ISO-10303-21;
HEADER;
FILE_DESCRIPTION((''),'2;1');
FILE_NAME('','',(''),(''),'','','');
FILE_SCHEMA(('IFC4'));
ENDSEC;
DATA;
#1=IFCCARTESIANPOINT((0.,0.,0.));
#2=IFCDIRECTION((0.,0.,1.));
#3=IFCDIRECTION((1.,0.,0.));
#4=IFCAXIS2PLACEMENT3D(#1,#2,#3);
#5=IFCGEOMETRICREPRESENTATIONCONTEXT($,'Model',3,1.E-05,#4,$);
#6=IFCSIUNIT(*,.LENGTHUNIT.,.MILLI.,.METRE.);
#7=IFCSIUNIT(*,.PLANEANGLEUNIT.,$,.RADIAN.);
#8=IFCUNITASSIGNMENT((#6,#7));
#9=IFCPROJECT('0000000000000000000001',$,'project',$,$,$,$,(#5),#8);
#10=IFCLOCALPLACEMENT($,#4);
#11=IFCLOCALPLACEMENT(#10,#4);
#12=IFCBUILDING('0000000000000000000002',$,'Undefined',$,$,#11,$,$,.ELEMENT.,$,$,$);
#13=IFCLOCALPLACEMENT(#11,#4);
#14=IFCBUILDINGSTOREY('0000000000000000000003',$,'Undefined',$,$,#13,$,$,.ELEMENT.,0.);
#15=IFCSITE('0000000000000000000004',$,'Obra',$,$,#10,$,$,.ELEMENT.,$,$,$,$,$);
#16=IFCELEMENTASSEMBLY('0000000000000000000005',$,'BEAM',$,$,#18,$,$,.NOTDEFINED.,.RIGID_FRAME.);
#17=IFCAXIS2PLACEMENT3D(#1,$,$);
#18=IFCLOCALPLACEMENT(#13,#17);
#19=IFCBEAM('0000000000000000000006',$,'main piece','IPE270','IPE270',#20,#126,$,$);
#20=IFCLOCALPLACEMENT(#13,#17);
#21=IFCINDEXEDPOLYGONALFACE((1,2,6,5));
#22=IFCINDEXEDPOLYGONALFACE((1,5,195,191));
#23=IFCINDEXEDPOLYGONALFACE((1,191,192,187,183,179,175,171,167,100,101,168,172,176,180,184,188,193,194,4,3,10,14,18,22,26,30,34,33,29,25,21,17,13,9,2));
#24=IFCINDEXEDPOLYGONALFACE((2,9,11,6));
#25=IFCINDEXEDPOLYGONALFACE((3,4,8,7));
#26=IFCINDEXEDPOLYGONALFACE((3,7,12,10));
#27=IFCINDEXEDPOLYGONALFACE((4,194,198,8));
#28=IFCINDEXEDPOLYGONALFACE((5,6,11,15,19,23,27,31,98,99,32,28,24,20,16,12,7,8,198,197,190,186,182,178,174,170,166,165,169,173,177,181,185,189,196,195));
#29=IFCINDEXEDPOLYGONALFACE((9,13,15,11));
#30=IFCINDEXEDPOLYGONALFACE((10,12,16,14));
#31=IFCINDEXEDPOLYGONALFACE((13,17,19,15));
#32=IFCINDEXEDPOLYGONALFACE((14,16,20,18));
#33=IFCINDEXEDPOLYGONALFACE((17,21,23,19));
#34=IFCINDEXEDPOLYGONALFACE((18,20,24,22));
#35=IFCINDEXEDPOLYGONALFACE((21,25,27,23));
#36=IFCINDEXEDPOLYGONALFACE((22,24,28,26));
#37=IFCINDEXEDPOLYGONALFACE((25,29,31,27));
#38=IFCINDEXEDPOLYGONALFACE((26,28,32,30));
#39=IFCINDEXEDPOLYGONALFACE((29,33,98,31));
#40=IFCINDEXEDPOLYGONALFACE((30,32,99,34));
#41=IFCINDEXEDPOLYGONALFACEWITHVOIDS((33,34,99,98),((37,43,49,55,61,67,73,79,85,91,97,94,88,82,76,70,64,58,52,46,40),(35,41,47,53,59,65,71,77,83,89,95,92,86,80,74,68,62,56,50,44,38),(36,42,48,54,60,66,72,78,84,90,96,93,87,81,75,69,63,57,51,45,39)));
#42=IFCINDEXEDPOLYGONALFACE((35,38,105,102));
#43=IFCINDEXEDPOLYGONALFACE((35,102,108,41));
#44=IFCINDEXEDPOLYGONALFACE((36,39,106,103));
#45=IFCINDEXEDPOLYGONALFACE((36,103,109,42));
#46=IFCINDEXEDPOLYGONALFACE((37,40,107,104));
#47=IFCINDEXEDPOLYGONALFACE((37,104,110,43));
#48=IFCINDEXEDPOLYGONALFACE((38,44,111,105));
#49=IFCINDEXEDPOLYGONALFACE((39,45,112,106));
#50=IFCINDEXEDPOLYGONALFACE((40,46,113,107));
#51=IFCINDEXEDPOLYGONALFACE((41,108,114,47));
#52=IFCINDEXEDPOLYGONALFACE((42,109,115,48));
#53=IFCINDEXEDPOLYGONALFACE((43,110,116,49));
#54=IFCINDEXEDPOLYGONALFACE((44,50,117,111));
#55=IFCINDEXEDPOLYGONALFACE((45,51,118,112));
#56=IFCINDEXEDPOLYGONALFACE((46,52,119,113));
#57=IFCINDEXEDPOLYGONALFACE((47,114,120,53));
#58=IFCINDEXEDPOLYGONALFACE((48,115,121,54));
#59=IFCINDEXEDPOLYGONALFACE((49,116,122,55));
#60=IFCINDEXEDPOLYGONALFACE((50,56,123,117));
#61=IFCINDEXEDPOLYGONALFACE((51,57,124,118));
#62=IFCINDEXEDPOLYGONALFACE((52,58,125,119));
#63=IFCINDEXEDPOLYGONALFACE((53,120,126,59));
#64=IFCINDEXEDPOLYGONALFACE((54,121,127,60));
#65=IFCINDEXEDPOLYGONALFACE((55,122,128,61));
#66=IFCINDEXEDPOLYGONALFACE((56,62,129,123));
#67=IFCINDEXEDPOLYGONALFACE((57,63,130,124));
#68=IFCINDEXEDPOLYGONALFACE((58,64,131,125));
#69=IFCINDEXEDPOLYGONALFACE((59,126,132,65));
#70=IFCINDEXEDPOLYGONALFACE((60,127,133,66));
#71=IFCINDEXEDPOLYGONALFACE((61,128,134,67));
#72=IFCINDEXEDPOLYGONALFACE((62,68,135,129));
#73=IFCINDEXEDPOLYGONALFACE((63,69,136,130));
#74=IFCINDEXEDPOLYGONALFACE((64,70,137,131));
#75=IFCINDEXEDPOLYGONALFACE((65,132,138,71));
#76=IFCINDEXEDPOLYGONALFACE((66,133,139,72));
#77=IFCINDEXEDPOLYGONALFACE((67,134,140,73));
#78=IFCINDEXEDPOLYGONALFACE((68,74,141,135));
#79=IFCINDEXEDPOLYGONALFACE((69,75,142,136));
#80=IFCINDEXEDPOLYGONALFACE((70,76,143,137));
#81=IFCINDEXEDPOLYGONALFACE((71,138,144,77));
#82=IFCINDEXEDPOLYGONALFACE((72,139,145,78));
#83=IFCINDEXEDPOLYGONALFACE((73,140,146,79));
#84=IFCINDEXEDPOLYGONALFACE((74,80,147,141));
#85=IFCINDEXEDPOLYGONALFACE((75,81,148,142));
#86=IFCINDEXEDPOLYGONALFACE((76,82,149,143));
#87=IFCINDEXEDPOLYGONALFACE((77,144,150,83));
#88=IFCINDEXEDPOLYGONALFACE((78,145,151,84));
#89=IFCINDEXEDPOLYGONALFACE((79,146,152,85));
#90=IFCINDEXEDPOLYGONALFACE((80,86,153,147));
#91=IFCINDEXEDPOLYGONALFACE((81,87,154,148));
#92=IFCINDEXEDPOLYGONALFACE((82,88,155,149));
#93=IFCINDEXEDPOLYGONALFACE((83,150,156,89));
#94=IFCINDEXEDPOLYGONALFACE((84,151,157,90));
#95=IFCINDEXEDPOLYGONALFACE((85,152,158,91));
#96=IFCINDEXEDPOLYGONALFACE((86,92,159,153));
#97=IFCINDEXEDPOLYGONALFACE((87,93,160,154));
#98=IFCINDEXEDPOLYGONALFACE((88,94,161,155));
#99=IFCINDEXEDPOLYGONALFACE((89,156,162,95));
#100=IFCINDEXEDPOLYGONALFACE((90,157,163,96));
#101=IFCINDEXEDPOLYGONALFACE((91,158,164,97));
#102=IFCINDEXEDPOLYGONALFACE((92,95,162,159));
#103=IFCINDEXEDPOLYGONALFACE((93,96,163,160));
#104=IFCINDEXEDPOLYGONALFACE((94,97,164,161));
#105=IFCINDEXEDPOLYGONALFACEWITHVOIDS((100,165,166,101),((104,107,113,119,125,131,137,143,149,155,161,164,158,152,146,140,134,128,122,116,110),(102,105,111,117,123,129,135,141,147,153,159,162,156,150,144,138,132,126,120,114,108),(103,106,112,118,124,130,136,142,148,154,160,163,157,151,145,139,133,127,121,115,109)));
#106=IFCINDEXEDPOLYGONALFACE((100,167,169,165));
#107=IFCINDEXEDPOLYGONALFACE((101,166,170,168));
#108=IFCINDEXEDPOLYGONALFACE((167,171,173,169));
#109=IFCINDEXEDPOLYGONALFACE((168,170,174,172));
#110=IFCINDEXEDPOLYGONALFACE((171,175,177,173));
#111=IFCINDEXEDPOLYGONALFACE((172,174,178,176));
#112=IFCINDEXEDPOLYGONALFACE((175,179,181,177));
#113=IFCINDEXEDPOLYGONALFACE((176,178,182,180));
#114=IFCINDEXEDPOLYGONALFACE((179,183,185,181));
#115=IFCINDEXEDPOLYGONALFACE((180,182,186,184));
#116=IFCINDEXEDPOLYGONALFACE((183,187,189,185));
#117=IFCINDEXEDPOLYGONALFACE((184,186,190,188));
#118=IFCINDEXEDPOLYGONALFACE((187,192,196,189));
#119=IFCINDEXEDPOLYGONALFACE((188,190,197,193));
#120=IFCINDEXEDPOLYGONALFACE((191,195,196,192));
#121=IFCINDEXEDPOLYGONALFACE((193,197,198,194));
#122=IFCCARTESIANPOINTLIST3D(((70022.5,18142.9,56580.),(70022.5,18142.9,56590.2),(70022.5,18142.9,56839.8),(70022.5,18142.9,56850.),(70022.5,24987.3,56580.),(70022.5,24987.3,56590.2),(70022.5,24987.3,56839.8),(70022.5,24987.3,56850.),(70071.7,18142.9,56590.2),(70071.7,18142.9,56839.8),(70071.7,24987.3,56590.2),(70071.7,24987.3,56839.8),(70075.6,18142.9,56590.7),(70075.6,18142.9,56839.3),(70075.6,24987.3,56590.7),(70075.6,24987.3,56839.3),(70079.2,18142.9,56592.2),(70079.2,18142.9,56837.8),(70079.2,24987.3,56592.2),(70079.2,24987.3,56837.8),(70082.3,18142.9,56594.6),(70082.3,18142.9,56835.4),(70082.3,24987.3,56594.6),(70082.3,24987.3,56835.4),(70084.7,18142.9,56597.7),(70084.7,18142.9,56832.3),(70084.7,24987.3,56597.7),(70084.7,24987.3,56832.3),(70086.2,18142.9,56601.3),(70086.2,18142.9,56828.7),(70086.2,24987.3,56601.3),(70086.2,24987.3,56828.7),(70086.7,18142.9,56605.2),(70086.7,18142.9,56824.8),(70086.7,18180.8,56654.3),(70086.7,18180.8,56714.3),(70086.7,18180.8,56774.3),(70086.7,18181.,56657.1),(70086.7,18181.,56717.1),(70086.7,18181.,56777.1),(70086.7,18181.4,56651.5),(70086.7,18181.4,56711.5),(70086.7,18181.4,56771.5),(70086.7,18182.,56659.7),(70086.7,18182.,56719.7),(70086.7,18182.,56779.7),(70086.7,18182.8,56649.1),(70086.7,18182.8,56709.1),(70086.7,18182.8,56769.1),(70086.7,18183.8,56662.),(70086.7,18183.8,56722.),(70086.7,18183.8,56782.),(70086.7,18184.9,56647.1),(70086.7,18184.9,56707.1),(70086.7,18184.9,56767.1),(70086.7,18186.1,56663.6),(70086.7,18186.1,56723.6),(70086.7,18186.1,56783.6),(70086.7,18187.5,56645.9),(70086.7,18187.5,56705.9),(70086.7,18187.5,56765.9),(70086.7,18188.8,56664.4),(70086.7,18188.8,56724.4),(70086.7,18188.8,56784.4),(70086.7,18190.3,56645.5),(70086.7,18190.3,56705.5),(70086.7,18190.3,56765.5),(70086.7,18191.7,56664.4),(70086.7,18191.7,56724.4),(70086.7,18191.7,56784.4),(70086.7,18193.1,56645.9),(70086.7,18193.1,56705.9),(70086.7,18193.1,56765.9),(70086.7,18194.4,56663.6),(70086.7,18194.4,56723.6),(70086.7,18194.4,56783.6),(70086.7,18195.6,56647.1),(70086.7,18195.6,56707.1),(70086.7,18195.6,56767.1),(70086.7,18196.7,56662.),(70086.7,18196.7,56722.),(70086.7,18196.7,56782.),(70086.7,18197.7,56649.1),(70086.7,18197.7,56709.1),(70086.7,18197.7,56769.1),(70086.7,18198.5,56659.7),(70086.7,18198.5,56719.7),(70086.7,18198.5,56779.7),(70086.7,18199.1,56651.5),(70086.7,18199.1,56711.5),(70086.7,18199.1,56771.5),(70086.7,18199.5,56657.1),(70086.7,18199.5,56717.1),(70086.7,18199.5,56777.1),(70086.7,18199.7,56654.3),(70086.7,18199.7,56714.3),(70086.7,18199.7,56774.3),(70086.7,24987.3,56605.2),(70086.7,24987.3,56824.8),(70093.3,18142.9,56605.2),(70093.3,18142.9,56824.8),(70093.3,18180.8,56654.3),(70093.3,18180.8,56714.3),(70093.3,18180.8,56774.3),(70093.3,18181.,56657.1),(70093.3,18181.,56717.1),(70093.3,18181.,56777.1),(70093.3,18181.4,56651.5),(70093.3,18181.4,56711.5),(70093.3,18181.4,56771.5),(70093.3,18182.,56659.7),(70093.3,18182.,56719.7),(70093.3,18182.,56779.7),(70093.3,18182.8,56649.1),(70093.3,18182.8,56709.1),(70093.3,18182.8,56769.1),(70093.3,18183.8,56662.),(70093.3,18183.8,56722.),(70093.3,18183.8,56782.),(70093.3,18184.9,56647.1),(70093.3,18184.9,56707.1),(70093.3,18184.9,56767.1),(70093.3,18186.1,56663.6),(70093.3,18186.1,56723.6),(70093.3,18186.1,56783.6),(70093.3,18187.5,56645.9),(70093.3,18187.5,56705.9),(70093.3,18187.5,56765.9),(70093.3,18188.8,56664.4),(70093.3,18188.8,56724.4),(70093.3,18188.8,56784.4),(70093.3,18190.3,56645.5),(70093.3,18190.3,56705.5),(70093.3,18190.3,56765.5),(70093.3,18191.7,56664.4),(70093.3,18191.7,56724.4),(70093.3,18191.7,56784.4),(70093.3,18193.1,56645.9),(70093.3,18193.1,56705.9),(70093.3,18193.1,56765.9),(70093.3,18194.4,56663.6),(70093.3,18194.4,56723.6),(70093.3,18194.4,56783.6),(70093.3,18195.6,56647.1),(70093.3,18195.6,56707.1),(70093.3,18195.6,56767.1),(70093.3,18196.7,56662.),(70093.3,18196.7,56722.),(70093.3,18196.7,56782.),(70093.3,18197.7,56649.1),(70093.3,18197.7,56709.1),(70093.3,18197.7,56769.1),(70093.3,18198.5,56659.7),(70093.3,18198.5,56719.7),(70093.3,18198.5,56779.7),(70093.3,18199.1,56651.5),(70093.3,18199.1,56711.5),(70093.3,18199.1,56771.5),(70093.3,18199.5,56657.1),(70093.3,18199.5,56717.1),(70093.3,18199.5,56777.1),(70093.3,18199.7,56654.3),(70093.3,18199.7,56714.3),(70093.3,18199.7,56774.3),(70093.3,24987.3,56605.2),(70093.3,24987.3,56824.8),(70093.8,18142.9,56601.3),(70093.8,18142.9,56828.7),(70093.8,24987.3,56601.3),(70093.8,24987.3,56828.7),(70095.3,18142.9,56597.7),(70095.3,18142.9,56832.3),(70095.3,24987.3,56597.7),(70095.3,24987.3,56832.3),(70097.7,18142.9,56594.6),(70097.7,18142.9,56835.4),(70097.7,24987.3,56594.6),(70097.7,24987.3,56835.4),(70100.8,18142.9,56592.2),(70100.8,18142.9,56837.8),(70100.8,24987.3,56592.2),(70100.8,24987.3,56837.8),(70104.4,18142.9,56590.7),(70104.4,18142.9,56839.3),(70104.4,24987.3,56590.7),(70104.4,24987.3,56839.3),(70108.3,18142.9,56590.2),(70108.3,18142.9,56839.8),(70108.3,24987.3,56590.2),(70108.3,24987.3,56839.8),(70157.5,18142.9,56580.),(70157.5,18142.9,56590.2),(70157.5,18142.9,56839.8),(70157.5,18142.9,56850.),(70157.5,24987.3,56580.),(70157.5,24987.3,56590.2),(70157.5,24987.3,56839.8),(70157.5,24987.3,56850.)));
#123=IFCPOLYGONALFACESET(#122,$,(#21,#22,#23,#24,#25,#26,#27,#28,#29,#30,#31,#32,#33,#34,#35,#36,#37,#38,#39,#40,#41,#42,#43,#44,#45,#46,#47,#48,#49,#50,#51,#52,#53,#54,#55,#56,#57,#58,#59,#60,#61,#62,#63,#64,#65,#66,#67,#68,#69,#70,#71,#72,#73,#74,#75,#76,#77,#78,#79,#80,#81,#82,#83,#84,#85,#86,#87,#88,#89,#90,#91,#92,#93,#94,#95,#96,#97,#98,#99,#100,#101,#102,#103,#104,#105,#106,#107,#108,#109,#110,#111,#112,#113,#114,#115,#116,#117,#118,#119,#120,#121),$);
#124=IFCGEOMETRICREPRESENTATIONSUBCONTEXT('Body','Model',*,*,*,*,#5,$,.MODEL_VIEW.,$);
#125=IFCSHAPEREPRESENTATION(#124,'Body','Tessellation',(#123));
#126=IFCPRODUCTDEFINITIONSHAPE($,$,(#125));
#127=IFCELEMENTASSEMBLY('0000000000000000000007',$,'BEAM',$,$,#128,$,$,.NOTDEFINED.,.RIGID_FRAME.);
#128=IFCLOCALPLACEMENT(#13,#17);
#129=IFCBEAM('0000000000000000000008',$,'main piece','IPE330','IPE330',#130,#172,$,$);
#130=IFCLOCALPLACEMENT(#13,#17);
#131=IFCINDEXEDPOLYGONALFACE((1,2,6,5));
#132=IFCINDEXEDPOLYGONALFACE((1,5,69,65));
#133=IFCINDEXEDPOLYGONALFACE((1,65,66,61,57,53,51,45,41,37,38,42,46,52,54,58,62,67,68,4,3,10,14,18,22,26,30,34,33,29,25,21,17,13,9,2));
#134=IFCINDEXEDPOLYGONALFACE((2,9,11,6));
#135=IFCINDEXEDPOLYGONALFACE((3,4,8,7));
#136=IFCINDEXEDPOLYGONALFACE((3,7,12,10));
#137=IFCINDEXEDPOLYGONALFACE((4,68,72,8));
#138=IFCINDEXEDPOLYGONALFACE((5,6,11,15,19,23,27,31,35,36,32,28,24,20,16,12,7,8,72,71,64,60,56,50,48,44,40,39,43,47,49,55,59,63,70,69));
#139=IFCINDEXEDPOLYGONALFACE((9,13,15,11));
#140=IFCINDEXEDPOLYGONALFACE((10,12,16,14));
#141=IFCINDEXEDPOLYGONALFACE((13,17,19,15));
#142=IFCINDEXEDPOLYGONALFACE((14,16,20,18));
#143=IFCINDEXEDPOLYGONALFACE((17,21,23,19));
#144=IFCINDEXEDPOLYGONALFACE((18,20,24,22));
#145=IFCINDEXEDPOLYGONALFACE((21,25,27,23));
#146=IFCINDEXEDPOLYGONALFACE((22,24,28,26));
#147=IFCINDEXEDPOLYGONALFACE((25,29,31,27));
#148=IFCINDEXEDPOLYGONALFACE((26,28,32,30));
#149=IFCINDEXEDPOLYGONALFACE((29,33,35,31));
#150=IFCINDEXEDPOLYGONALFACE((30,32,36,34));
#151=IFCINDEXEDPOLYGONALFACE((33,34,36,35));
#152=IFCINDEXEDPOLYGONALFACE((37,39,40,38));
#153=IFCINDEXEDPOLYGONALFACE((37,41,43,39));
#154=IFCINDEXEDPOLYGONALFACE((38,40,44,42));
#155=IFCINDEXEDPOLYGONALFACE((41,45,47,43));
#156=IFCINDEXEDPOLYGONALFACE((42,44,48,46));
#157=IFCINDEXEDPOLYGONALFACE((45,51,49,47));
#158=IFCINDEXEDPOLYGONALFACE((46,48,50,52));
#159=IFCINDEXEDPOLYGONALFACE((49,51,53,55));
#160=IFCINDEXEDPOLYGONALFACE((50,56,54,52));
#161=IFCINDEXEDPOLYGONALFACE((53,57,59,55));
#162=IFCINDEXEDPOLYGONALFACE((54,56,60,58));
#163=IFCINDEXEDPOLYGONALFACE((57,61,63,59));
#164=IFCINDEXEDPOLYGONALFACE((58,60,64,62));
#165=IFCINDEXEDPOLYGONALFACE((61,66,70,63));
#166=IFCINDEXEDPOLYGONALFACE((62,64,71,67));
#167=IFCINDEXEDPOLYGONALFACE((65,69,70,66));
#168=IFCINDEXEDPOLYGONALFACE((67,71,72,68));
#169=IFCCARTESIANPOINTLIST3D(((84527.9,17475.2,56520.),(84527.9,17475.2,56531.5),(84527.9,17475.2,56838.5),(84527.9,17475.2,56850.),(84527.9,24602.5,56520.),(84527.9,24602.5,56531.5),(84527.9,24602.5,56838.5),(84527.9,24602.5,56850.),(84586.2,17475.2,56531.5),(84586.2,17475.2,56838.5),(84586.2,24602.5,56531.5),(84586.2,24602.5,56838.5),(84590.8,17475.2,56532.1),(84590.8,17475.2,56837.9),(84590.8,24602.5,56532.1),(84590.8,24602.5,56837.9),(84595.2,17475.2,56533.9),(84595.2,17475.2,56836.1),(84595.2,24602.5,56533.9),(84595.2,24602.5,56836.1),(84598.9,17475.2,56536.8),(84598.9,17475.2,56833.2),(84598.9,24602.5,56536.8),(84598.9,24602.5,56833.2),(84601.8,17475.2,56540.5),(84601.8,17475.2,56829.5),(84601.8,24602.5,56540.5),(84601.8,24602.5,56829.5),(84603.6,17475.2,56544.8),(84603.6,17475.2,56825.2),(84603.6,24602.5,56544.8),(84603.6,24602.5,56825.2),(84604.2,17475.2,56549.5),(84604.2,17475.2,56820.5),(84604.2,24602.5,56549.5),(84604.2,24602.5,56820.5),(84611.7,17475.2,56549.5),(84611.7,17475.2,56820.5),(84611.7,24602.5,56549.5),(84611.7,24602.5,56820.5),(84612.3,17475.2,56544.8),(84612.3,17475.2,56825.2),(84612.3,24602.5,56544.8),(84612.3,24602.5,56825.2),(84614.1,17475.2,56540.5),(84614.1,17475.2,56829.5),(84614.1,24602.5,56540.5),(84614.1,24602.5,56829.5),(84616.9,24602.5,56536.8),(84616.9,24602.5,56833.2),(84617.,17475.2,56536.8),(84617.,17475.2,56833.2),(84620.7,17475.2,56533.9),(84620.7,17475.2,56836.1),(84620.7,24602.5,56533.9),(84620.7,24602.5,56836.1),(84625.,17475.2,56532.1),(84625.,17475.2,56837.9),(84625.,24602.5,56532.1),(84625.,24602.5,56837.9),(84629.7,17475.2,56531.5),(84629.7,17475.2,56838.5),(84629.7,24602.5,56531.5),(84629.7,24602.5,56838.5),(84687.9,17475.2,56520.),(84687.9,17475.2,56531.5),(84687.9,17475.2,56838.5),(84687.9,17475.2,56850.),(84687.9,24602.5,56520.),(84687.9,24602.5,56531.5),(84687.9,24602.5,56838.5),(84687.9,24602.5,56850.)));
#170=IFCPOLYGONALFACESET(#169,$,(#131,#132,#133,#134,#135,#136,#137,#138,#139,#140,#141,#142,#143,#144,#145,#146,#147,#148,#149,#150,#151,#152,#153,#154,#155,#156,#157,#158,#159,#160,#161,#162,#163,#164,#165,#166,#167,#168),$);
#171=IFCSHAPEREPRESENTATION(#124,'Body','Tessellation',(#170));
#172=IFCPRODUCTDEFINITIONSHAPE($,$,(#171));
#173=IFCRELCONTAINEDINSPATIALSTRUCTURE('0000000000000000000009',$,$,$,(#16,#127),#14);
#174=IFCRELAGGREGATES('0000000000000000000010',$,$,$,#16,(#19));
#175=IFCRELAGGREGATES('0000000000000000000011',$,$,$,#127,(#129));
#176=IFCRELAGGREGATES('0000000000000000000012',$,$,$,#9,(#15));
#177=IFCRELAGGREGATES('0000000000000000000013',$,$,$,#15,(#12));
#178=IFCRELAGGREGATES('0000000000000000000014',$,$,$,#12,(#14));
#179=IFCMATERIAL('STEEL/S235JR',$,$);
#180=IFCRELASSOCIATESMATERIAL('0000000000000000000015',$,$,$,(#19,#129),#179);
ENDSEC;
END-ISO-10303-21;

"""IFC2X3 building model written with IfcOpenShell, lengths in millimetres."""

from ifc_helpers import new_model, si_unit, frame, origin_with_axes, origin_2d_with_axis, place, context, subcontext, project, spatial, circle, i_section, extrude, clip, halfspace, source, transform, mapped, material, element, aggregate, save


model = new_model("IFC2X3")

# Units and contexts
model_context = context("Model", 3, precision=1e-05, world=origin_with_axes())
body_context = subcontext(model_context, "Body", "Model", "MODEL_VIEW")
ifc_project = project(units=[si_unit("LENGTHUNIT", "METRE", prefix="MILLI"), si_unit("PLANEANGLEUNIT", "RADIAN")], contexts=[model_context])

# Site, building, storey
site_placement = place(None, origin_with_axes())
site = spatial("IfcSite", under=ifc_project, at=site_placement, Name="Obra", CompositionType="ELEMENT")
building_placement = place(site_placement, origin_with_axes())
building = spatial("IfcBuilding", under=site, at=building_placement, Name="Undefined", CompositionType="ELEMENT")
storey_placement = place(building_placement, origin_with_axes())
storey = spatial("IfcBuildingStorey", under=building, at=storey_placement, Name="Undefined", CompositionType="ELEMENT", Elevation=0.0)

# Shared definitions
ifc_material = material(Name="STEEL/S235JR")

# Element assembly, beam, opening
assembly_1_placement = place(storey_placement, origin_with_axes())
assembly_1 = element("IfcElementAssembly", 1, at=assembly_1_placement, inside=storey, Name="BEAM", AssemblyPlace="NOTDEFINED", PredefinedType="RIGID_FRAME")
beam_1_placement = place(assembly_1_placement, frame((70090.0, 18142.9, 56715.0), z_axis=(0.0, 0.0, 1.0), x_axis=(0.0, 1.0, 0.0)))
beam_1 = element("IfcBeam", 2, at=beam_1_placement, material=ifc_material, Name="main piece", Description="IPE270", ObjectType="IPE270", context=body_context, shape_type="Clipping", body=[
    clip(extrude(i_section(OverallWidth=135.0, OverallDepth=270.0, WebThickness=6.6, FlangeThickness=10.2, FilletRadius=15.0, at=origin_2d_with_axis()), frame((6844.4, 0.0, 0.0), z_axis=(-1.0, 0.0, 0.0), x_axis=(0.0, -1.0, 0.0)), (0.0, 0.0, 1.0), 6844.4), halfspace(frame((-2.1, 60.0, -120.0), z_axis=(-1.0, -0.000019, 0.0), x_axis=(0.0, 0.0, 1.0)), False)),
])
shared_shape_1 = source(origin_with_axes(), body_context, "Body", "SweptSolid", [
    extrude(circle(Radius=9.5, at=origin_2d_with_axis()), frame((0.0, -3.4, 0.0), z_axis=(0.0, 1.0, 0.0), x_axis=(1.0, 0.0, 0.0)), (0.0, 0.0, 1.0), 6.8),
])
opening_1_placement = place(assembly_1_placement, frame((70090.0, 18140.3, 56835.0), z_axis=(0.0, 1.0, 0.0), x_axis=(0.0, 0.0, -1.0)))
element("IfcOpeningElement", 3, at=opening_1_placement, cuts=beam_1, ObjectType="Opening", context=body_context, shape_type="MappedRepresentation", body=[
    mapped(shared_shape_1, transform((60.0, 0.0, 50.0))),
    mapped(shared_shape_1, transform((120.0, 0.0, 50.0))),
    mapped(shared_shape_1, transform((180.0, 0.0, 50.0))),
])
aggregate(assembly_1, [beam_1])

# Element assembly, beam
assembly_2_placement = place(storey_placement, origin_with_axes())
assembly_2 = element("IfcElementAssembly", 4, at=assembly_2_placement, inside=storey, Name="BEAM", AssemblyPlace="NOTDEFINED", PredefinedType="RIGID_FRAME")
beam_2_placement = place(assembly_2_placement, frame((84607.9, 17475.2, 56685.0), z_axis=(0.0, 0.0, 1.0), x_axis=(-0.000002, 1.0, 0.0)))
beam_2 = element("IfcBeam", 5, at=beam_2_placement, material=ifc_material, Name="main piece", Description="IPE330", ObjectType="IPE330", context=body_context, shape_type="SweptSolid", body=[
    extrude(i_section(OverallWidth=160.0, OverallDepth=330.0, WebThickness=7.5, FlangeThickness=11.5, FilletRadius=18.0, at=origin_2d_with_axis()), frame((7127.3, 0.0, 0.0), z_axis=(-1.0, 0.0, 0.0), x_axis=(0.0, -1.0, 0.0)), (0.0, 0.0, 1.0), 7127.3),
])
aggregate(assembly_2, [beam_2])

save(model, "model.ifc")
